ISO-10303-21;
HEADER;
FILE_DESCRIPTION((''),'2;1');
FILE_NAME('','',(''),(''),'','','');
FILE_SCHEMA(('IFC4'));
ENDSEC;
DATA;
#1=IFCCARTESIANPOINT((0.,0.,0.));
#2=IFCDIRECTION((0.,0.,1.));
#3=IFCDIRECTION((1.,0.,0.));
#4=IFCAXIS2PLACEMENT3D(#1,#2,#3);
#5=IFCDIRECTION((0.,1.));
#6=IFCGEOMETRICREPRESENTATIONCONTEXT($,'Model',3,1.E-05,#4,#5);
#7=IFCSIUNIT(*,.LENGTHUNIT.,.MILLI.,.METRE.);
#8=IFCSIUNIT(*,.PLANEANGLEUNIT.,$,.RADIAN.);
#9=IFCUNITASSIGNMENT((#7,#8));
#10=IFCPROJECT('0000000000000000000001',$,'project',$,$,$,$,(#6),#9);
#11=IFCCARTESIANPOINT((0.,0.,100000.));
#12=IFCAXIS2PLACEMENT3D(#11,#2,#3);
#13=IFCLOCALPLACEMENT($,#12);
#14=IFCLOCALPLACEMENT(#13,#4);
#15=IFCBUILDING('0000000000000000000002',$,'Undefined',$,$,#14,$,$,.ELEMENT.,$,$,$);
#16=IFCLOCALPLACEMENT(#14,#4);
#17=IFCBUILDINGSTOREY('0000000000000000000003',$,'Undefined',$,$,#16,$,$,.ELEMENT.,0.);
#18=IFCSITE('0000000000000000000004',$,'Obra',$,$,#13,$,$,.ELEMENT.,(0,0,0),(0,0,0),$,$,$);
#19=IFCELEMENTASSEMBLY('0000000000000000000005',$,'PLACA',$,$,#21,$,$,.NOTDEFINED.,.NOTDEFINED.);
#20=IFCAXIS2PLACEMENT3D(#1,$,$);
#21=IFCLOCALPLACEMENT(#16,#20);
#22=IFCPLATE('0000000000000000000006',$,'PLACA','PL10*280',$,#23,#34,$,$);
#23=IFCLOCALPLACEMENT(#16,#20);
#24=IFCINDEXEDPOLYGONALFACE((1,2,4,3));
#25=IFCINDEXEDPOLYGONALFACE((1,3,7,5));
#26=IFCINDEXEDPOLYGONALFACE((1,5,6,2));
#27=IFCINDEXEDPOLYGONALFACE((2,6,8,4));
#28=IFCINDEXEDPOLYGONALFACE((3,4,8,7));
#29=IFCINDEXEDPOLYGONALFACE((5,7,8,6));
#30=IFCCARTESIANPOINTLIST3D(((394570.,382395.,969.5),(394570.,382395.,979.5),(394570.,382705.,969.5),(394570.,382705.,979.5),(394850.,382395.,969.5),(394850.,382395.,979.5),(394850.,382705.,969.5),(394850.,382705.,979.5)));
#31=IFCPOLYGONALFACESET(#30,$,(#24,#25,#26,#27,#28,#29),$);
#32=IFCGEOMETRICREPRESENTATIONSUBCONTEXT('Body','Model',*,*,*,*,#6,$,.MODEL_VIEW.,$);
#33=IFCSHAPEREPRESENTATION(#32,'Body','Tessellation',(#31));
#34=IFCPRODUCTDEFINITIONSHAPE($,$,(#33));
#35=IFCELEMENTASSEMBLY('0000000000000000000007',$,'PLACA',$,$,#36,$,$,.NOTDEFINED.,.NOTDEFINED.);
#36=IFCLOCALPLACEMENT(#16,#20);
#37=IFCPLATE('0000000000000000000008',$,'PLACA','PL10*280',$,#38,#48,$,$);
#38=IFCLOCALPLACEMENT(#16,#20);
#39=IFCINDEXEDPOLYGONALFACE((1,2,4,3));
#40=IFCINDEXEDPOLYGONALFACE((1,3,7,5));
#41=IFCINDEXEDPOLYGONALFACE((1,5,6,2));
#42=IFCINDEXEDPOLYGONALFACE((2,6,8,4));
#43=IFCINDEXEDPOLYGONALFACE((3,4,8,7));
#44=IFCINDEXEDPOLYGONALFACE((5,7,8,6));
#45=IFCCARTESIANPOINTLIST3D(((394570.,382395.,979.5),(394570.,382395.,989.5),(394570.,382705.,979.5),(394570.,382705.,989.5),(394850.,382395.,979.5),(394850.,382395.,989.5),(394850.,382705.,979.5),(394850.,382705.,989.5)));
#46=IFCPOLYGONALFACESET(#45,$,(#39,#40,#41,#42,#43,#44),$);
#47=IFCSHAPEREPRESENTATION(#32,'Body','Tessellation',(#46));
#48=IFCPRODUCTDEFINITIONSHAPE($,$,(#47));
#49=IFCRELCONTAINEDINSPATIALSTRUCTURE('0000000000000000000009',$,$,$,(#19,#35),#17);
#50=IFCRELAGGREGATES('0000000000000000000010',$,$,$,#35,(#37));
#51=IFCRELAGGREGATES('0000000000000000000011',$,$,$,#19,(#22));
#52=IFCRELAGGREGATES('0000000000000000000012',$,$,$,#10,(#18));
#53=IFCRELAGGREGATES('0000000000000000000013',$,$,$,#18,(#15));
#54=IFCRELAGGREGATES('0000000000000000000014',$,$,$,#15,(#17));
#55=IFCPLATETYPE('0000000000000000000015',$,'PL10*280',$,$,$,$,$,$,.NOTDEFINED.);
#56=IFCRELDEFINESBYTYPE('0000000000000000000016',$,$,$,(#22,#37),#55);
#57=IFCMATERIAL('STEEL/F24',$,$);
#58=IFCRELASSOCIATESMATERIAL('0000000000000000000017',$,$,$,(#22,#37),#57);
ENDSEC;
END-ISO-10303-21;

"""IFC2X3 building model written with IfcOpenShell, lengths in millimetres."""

from ifc_helpers import new_model, si_unit, direction, frame, origin_with_axes, place, context, subcontext, project, spatial, polyline, outline, extrude, material, type_object, element, aggregate, save


model = new_model("IFC2X3")

# Units and contexts
model_context = context("Model", 3, precision=1e-05, world=origin_with_axes(), true_north=direction((0.0, 1.0)))
body_context = subcontext(model_context, "Body", "Model", "MODEL_VIEW")
ifc_project = project(units=[si_unit("LENGTHUNIT", "METRE", prefix="MILLI"), si_unit("PLANEANGLEUNIT", "RADIAN")], contexts=[model_context])

# Site, building, storey
site_placement = place(None, frame((0.0, 0.0, 100000.0), z_axis=(0.0, 0.0, 1.0), x_axis=(1.0, 0.0, 0.0)))
site = spatial("IfcSite", under=ifc_project, at=site_placement, Name="Obra", CompositionType="ELEMENT", RefLatitude=(0, 0, 0), RefLongitude=(0, 0, 0))
building_placement = place(site_placement, origin_with_axes())
building = spatial("IfcBuilding", under=site, at=building_placement, Name="Undefined", CompositionType="ELEMENT")
storey_placement = place(building_placement, origin_with_axes())
storey = spatial("IfcBuildingStorey", under=building, at=storey_placement, Name="Undefined", CompositionType="ELEMENT", Elevation=0.0)

# Shared definitions
ifc_material_1 = material(Name="STEEL/F24")

# Element assemblies, plates
plate_type_1 = type_object("IfcPlateType", Name="PL10*280", PredefinedType="NOTDEFINED")
assembly_1_placement = place(storey_placement, origin_with_axes())
assembly_1 = element("IfcElementAssembly", 1, at=assembly_1_placement, inside=storey, Name="PLACA", AssemblyPlace="NOTDEFINED", PredefinedType="NOTDEFINED")
plate_1_placement = place(assembly_1_placement, frame((394570.0, 382395.0, 974.5), z_axis=(0.0, 0.0, 1.0), x_axis=(1.0, 0.0, 0.0)))
plate_1 = element("IfcPlate", 2, at=plate_1_placement, type_object=plate_type_1, material=ifc_material_1, Name="PLACA", Description="PL10*280", context=body_context, shape_type="SweptSolid", body=[
    extrude(outline(polyline([(0.0, 0.0), (280.0, 0.0), (280.0, 310.0), (0.0, 310.0), (0.0, 0.0)])), frame((0.0, 0.0, -5.0), z_axis=(0.0, 0.0, 1.0), x_axis=(1.0, 0.0, 0.0)), (0.0, 0.0, 1.0), 10.0),
])
assembly_2_placement = place(storey_placement, origin_with_axes())
assembly_2 = element("IfcElementAssembly", 3, at=assembly_2_placement, inside=storey, Name="PLACA", AssemblyPlace="NOTDEFINED", PredefinedType="NOTDEFINED")
plate_2_placement = place(assembly_2_placement, frame((394570.0, 382395.0, 984.5), z_axis=(0.0, 0.0, 1.0), x_axis=(1.0, 0.0, 0.0)))
plate_2 = element("IfcPlate", 4, at=plate_2_placement, type_object=plate_type_1, material=ifc_material_1, Name="PLACA", Description="PL10*280", context=body_context, shape_type="SweptSolid", body=[
    extrude(outline(polyline([(0.0, 0.0), (280.0, 0.0), (280.0, 310.0), (0.0, 310.0), (0.0, 0.0)])), frame((0.0, 0.0, -5.0), z_axis=(0.0, 0.0, 1.0), x_axis=(1.0, 0.0, 0.0)), (0.0, 0.0, 1.0), 10.0),
])
aggregate(assembly_2, [plate_2])

aggregate(assembly_1, [plate_1])

save(model, "model.ifc")
